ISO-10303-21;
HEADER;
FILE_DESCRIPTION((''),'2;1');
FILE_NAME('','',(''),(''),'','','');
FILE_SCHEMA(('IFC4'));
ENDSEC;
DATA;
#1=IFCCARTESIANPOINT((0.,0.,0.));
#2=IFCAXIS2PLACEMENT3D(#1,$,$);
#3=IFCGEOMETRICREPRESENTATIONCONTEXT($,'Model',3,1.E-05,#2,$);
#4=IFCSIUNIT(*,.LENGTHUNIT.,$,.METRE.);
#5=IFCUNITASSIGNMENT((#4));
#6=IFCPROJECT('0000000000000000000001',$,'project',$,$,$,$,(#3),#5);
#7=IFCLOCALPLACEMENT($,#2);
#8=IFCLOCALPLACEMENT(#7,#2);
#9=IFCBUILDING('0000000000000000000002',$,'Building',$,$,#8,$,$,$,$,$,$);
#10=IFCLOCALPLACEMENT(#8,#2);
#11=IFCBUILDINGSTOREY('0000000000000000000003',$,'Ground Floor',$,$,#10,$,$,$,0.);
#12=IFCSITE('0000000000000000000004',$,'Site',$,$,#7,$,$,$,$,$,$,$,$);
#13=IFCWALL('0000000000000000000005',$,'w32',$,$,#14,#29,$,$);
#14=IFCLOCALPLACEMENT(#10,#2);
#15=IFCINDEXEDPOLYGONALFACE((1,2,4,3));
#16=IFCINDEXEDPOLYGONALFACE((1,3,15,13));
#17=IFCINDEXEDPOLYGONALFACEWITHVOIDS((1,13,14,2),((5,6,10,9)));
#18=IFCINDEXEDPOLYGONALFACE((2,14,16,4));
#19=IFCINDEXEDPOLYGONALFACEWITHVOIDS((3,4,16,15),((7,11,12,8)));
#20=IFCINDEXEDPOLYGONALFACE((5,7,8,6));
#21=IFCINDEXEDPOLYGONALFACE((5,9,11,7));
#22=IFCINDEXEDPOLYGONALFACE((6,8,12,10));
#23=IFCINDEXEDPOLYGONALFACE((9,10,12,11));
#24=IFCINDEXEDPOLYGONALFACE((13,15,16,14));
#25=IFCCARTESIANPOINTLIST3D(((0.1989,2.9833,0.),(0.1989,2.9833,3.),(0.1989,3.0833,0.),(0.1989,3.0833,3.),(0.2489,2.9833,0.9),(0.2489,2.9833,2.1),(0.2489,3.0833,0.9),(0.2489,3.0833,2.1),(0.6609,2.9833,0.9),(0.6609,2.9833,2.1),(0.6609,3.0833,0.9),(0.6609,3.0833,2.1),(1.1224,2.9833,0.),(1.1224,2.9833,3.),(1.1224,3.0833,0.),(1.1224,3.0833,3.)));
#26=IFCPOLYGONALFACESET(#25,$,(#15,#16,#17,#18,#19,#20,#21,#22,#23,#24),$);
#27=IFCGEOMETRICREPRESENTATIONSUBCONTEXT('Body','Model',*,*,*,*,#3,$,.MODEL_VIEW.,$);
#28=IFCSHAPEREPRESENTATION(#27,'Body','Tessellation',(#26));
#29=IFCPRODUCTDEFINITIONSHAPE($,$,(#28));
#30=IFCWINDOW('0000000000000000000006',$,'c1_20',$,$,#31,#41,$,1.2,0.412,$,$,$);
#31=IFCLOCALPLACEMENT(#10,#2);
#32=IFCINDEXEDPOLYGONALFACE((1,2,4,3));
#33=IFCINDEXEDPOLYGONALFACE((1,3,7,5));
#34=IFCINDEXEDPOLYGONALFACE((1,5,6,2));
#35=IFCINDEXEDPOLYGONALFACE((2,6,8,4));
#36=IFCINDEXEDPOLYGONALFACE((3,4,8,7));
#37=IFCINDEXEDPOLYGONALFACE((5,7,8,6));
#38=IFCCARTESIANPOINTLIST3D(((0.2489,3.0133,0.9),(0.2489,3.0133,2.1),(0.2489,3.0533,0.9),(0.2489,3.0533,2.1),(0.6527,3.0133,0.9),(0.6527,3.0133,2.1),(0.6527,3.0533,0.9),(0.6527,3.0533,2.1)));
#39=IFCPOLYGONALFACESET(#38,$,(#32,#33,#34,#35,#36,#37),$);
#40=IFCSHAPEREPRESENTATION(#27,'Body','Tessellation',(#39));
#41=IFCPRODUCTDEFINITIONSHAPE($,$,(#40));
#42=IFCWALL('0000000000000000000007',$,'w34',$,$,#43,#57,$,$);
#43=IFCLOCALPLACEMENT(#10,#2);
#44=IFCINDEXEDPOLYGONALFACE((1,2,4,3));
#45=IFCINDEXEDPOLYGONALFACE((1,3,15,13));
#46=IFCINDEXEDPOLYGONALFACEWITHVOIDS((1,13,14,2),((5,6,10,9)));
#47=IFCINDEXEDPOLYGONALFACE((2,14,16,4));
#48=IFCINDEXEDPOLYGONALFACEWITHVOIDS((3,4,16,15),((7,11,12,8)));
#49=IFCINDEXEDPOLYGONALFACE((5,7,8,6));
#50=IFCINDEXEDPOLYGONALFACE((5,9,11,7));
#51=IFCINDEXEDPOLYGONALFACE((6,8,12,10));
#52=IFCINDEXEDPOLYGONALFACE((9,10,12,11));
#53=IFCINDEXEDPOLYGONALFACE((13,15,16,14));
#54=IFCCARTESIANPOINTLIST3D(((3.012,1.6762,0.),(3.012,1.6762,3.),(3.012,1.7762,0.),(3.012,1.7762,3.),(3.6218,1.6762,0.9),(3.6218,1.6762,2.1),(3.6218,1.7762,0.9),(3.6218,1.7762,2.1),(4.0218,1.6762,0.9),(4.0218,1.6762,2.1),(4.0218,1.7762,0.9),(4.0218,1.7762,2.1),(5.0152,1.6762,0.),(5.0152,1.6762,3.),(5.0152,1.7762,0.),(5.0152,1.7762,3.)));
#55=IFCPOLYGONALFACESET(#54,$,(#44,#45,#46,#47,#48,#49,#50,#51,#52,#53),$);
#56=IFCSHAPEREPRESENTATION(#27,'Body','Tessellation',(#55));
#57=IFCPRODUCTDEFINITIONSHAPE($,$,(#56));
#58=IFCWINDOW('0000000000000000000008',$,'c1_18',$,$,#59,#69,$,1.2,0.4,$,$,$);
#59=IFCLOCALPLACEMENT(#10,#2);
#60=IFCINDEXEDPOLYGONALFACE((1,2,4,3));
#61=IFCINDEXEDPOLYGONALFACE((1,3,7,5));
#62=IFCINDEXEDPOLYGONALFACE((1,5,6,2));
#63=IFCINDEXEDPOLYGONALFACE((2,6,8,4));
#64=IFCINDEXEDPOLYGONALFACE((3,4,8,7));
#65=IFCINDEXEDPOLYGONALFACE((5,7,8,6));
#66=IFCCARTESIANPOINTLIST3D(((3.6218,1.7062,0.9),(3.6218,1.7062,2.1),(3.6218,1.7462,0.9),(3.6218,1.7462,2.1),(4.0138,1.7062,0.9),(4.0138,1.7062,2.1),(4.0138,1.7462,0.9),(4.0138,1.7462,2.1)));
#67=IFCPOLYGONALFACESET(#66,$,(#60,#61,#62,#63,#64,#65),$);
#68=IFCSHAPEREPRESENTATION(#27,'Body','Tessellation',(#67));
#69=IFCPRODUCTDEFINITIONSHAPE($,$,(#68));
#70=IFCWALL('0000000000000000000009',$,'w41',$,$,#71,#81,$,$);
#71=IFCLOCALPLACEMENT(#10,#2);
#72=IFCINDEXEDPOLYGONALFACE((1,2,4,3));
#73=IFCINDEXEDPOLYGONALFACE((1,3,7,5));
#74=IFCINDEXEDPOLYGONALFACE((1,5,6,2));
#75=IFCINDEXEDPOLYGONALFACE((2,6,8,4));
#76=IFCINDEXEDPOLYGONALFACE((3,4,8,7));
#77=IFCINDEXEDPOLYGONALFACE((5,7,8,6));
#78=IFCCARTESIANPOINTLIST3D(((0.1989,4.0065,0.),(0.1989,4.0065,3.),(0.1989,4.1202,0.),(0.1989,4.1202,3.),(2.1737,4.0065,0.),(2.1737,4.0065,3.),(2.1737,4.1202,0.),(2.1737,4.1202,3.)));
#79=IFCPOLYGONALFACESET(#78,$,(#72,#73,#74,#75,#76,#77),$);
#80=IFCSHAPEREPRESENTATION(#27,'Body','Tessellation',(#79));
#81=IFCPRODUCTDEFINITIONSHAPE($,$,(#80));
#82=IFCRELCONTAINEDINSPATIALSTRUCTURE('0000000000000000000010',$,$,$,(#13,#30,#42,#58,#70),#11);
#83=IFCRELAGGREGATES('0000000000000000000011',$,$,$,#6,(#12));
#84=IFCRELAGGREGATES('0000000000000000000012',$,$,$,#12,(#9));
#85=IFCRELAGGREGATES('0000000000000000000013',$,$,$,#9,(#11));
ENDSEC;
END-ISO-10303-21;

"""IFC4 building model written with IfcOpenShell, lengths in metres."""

from ifc_helpers import new_model, si_unit, frame, origin, place, context, subcontext, project, spatial, polyline, outline, extrude, element, fill, save


model = new_model("IFC4")

# Units and contexts
model_context = context("Model", 3, precision=1e-05, world=origin())
body_context = subcontext(model_context, "Body", "Model", "MODEL_VIEW")
ifc_project = project(units=[si_unit("LENGTHUNIT", "METRE")], contexts=[model_context])

# Site, building, storey
site_placement = place(None, origin())
site = spatial("IfcSite", under=ifc_project, at=site_placement, Name="Site")
building_placement = place(site_placement, origin())
building = spatial("IfcBuilding", under=site, at=building_placement, Name="Building")
storey_placement = place(building_placement, origin())
storey = spatial("IfcBuildingStorey", under=building, at=storey_placement, Name="Ground Floor", Elevation=0.0)

# Walls, openings, windows
wall_1_placement = place(storey_placement, frame((0.1989, 3.0333, 0.0), x_axis=(1.0, 0.0, 0.0)))
wall_1 = element("IfcWall", 1, at=wall_1_placement, inside=storey, Name="w32", context=body_context, shape_type="SweptSolid", body=[
    extrude(outline(polyline([(0.0, -0.05), (0.9235, -0.05), (0.9235, 0.05), (0.0, 0.05), (0.0, -0.05)])), origin(), (0.0, 0.0, 1.0), 3.0),
])
opening_1_placement = place(wall_1_placement, frame((0.05, 0.0, 0.0)))
opening_1 = element("IfcOpeningElement", 2, at=opening_1_placement, cuts=wall_1, context=body_context, shape_type="SweptSolid", body=[
    extrude(outline(polyline([(0.0, -0.0525), (0.412, -0.0525), (0.412, 0.0525), (0.0, 0.0525), (0.0, -0.0525)])), frame((0.0, 0.0, 0.9)), (0.0, 0.0, 1.0), 1.2),
])
window_1_placement = place(wall_1_placement, frame((0.05, 0.0, 0.0)))
window_1 = element("IfcWindow", 3, at=window_1_placement, inside=storey, Name="c1_20", OverallHeight=1.2, OverallWidth=0.412, context=body_context, shape_type="SweptSolid", body=[
    extrude(outline(polyline([(0.0, -0.02), (0.4038, -0.02), (0.4038, 0.02), (0.0, 0.02), (0.0, -0.02)])), frame((0.0, 0.0, 0.9)), (0.0, 0.0, 1.0), 1.2),
])
fill(opening_1, window_1)
wall_2_placement = place(storey_placement, frame((3.012, 1.7262, 0.0), x_axis=(1.0, 0.0, 0.0)))
wall_2 = element("IfcWall", 4, at=wall_2_placement, inside=storey, Name="w34", context=body_context, shape_type="SweptSolid", body=[
    extrude(outline(polyline([(0.0, -0.05), (2.0033, -0.05), (2.0033, 0.05), (0.0, 0.05), (0.0, -0.05)])), origin(), (0.0, 0.0, 1.0), 3.0),
])
opening_2_placement = place(wall_2_placement, frame((0.6098, 0.0, 0.0)))
opening_2 = element("IfcOpeningElement", 5, at=opening_2_placement, cuts=wall_2, context=body_context, shape_type="SweptSolid", body=[
    extrude(outline(polyline([(0.0, -0.0525), (0.4, -0.0525), (0.4, 0.0525), (0.0, 0.0525), (0.0, -0.0525)])), frame((0.0, 0.0, 0.9)), (0.0, 0.0, 1.0), 1.2),
])
window_2_placement = place(wall_2_placement, frame((0.6098, 0.0, 0.0)))
window_2 = element("IfcWindow", 6, at=window_2_placement, inside=storey, Name="c1_18", OverallHeight=1.2, OverallWidth=0.4, context=body_context, shape_type="SweptSolid", body=[
    extrude(outline(polyline([(0.0, -0.02), (0.392, -0.02), (0.392, 0.02), (0.0, 0.02), (0.0, -0.02)])), frame((0.0, 0.0, 0.9)), (0.0, 0.0, 1.0), 1.2),
])
fill(opening_2, window_2)

# Wall
wall_3_placement = place(storey_placement, frame((0.1989, 4.0633, 0.0), x_axis=(1.0, 0.0, 0.0)))
element("IfcWall", 7, at=wall_3_placement, inside=storey, Name="w41", context=body_context, shape_type="SweptSolid", body=[
    extrude(outline(polyline([(0.0, -0.0568), (1.9748, -0.0568), (1.9748, 0.0568), (0.0, 0.0568), (0.0, -0.0568)])), origin(), (0.0, 0.0, 1.0), 3.0),
])

save(model, "model.ifc")
